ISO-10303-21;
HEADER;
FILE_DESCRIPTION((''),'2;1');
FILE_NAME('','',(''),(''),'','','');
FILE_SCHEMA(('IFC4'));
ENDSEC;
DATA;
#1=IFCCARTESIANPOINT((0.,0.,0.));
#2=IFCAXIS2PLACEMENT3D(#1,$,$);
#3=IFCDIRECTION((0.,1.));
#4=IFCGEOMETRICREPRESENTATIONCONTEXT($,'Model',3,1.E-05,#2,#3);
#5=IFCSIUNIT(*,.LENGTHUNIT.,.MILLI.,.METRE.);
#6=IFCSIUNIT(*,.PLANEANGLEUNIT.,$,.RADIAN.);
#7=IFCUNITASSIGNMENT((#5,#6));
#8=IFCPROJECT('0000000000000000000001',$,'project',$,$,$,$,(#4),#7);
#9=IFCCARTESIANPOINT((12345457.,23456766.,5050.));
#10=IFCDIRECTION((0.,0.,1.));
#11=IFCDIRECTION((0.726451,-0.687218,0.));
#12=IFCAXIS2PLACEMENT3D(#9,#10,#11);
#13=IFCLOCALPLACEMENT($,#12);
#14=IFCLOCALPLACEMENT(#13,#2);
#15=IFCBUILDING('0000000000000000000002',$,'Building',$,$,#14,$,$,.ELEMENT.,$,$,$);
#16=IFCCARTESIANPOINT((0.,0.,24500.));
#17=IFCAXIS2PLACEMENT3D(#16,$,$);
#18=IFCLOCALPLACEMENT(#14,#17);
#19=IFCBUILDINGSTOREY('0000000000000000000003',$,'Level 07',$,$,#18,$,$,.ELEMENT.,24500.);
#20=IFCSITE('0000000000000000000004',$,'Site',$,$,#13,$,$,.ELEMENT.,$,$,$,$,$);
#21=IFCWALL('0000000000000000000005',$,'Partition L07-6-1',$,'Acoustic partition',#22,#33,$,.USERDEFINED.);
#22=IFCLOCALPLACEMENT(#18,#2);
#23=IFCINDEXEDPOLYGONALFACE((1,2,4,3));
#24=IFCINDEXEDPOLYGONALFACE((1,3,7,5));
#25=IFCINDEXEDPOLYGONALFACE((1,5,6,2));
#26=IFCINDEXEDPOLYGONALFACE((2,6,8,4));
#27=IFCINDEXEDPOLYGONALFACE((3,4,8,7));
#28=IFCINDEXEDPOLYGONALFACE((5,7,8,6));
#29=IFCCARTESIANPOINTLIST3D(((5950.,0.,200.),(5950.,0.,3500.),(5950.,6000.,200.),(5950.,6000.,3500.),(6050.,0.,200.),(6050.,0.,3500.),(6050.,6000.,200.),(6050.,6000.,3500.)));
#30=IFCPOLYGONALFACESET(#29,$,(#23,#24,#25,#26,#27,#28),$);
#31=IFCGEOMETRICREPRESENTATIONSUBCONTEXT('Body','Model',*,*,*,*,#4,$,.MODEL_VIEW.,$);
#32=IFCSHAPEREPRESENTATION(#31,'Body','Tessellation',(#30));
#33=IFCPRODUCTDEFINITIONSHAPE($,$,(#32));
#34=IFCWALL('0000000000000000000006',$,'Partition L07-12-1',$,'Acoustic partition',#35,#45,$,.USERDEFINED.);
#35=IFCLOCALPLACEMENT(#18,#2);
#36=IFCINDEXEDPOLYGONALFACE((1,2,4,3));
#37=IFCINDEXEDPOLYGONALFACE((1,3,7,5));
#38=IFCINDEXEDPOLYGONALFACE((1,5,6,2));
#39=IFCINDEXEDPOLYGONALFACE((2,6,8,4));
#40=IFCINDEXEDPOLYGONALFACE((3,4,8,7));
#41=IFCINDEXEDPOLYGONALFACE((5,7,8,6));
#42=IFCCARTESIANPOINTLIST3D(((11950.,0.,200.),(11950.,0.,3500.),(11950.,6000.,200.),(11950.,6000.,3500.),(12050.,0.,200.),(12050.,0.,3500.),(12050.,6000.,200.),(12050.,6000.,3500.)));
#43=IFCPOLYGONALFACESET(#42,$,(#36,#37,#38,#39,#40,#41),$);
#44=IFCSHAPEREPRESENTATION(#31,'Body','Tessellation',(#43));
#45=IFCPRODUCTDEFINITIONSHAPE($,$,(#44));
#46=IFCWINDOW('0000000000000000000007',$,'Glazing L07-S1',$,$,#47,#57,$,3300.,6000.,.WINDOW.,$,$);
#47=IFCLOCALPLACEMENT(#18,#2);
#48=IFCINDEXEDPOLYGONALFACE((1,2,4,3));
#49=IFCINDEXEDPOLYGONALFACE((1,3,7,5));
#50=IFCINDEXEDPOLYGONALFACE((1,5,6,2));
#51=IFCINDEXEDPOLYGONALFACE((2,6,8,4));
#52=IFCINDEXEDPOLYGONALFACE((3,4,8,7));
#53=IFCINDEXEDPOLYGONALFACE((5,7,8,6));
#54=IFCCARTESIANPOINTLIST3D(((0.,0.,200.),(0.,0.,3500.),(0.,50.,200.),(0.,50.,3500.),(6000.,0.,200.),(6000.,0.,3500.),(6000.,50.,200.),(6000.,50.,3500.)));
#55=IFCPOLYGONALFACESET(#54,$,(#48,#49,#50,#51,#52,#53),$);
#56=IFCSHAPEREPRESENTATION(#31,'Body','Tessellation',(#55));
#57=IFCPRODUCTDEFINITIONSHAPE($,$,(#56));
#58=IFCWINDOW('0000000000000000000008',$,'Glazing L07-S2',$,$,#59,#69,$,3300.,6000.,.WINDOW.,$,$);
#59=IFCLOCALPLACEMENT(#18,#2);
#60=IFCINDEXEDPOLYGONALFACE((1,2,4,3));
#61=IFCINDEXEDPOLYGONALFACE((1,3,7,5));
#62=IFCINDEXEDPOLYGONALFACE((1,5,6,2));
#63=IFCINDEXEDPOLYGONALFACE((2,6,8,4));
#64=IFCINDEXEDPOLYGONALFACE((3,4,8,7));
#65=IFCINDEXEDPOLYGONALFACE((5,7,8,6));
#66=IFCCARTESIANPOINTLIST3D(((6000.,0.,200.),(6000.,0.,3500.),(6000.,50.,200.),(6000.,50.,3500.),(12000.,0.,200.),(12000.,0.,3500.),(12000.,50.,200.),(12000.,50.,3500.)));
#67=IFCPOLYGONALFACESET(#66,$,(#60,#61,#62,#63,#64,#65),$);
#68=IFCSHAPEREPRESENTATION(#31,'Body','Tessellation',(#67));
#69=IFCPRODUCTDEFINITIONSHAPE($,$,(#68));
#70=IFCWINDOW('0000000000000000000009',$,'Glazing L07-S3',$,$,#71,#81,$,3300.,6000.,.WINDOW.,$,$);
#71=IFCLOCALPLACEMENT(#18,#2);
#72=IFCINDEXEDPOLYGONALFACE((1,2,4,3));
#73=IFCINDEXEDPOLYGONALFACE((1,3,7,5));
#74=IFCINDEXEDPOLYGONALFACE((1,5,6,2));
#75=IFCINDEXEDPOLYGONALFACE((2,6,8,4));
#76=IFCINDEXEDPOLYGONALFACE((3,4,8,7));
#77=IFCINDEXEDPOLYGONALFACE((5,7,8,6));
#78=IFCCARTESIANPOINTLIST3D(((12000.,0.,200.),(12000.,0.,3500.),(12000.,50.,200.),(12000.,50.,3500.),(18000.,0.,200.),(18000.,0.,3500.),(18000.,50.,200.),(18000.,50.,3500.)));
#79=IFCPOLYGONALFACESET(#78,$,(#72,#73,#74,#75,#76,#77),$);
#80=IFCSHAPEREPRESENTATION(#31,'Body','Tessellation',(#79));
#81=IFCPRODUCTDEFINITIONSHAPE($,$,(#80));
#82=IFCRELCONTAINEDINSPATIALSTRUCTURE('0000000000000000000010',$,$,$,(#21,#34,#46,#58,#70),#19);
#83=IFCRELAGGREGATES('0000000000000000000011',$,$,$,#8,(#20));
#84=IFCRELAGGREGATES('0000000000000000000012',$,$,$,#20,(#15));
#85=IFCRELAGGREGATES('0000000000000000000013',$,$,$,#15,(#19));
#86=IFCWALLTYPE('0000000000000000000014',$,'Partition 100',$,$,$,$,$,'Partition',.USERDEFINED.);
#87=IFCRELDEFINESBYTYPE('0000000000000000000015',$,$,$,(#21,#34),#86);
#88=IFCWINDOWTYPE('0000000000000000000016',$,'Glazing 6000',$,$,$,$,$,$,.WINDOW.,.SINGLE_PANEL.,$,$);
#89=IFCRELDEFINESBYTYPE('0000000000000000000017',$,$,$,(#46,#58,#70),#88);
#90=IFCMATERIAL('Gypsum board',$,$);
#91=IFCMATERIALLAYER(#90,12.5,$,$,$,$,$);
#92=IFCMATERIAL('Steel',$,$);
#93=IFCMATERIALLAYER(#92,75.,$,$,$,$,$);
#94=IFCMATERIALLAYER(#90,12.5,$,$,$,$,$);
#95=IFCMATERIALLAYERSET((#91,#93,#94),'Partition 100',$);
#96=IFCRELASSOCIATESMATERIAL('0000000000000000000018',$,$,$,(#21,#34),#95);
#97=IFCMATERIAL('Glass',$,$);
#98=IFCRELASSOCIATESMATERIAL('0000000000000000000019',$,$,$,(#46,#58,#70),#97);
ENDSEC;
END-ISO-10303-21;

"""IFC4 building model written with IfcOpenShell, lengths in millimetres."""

from ifc_helpers import new_model, si_unit, direction, frame, origin, place, context, subcontext, project, spatial, rectangle, extrude, material, layer, layer_set, layer_usage, type_object, element, save


model = new_model("IFC4")

# Units and contexts
model_context = context("Model", 3, precision=1e-05, world=origin(), true_north=direction((0.0, 1.0)))
body_context = subcontext(model_context, "Body", "Model", "MODEL_VIEW")
ifc_project = project(units=[si_unit("LENGTHUNIT", "METRE", prefix="MILLI"), si_unit("PLANEANGLEUNIT", "RADIAN")], contexts=[model_context])

# Site, building, storey
site_placement = place(None, frame((12345457.0, 23456766.0, 5050.0), z_axis=(0.0, 0.0, 1.0), x_axis=(0.726451, -0.687218, 0.0)))
site = spatial("IfcSite", under=ifc_project, at=site_placement, Name="Site", CompositionType="ELEMENT")
building_placement = place(site_placement, origin())
building = spatial("IfcBuilding", under=site, at=building_placement, Name="Building", CompositionType="ELEMENT")
storey_placement = place(building_placement, frame((0.0, 0.0, 24500.0)))
storey = spatial("IfcBuildingStorey", under=building, at=storey_placement, Name="Level 07", CompositionType="ELEMENT", Elevation=24500.0)

# Shared definitions
ifc_material_1 = material(Name="Steel")

# Walls
ifc_material_2 = material(Name="Gypsum board")
ifc_layer_1 = layer(ifc_material_2, 12.5)
ifc_layer_2 = layer(ifc_material_1, 75.0)
ifc_layer_3 = layer(ifc_material_2, 12.5)
ifc_layer_set_1 = layer_set([ifc_layer_1, ifc_layer_2, ifc_layer_3], Name="Partition 100")
ifc_layer_usage_1 = layer_usage(ifc_layer_set_1, "AXIS2", "POSITIVE", 0.0)
wall_type_1 = type_object("IfcWallType", Name="Partition 100", ElementType="Partition", PredefinedType="USERDEFINED")
for number, where, name in (
    (1, (5950.0, 0.0, 200.0), "Partition L07-6-1"),
    (2, (11950.0, 0.0, 200.0), "Partition L07-12-1"),
):
    element("IfcWall", number, at=place(storey_placement, frame(where)), inside=storey, type_object=wall_type_1, material=ifc_layer_usage_1, Name=name, ObjectType="Acoustic partition", PredefinedType="USERDEFINED", context=body_context, shape_type="SweptSolid", body=[
        extrude(rectangle(XDim=100.0, YDim=6000.0), frame((50.0, 3000.0, 0.0)), (0.0, 0.0, 1.0), 3300.0),
    ])

# Windows
ifc_material_3 = material(Name="Glass")
window_type = type_object("IfcWindowType", Name="Glazing 6000", PartitioningType="SINGLE_PANEL", PredefinedType="WINDOW")
for number, where, name in (
    (3, (0.0, 0.0, 200.0), "Glazing L07-S1"),
    (4, (6000.0, 0.0, 200.0), "Glazing L07-S2"),
    (5, (12000.0, 0.0, 200.0), "Glazing L07-S3"),
):
    element("IfcWindow", number, at=place(storey_placement, frame(where)), inside=storey, type_object=window_type, material=ifc_material_3, Name=name, OverallHeight=3300.0, OverallWidth=6000.0, PredefinedType="WINDOW", context=body_context, shape_type="SweptSolid", body=[
        extrude(rectangle(XDim=6000.0, YDim=50.0), frame((3000.0, 25.0, 0.0)), (0.0, 0.0, 1.0), 3300.0),
    ])

save(model, "model.ifc")
